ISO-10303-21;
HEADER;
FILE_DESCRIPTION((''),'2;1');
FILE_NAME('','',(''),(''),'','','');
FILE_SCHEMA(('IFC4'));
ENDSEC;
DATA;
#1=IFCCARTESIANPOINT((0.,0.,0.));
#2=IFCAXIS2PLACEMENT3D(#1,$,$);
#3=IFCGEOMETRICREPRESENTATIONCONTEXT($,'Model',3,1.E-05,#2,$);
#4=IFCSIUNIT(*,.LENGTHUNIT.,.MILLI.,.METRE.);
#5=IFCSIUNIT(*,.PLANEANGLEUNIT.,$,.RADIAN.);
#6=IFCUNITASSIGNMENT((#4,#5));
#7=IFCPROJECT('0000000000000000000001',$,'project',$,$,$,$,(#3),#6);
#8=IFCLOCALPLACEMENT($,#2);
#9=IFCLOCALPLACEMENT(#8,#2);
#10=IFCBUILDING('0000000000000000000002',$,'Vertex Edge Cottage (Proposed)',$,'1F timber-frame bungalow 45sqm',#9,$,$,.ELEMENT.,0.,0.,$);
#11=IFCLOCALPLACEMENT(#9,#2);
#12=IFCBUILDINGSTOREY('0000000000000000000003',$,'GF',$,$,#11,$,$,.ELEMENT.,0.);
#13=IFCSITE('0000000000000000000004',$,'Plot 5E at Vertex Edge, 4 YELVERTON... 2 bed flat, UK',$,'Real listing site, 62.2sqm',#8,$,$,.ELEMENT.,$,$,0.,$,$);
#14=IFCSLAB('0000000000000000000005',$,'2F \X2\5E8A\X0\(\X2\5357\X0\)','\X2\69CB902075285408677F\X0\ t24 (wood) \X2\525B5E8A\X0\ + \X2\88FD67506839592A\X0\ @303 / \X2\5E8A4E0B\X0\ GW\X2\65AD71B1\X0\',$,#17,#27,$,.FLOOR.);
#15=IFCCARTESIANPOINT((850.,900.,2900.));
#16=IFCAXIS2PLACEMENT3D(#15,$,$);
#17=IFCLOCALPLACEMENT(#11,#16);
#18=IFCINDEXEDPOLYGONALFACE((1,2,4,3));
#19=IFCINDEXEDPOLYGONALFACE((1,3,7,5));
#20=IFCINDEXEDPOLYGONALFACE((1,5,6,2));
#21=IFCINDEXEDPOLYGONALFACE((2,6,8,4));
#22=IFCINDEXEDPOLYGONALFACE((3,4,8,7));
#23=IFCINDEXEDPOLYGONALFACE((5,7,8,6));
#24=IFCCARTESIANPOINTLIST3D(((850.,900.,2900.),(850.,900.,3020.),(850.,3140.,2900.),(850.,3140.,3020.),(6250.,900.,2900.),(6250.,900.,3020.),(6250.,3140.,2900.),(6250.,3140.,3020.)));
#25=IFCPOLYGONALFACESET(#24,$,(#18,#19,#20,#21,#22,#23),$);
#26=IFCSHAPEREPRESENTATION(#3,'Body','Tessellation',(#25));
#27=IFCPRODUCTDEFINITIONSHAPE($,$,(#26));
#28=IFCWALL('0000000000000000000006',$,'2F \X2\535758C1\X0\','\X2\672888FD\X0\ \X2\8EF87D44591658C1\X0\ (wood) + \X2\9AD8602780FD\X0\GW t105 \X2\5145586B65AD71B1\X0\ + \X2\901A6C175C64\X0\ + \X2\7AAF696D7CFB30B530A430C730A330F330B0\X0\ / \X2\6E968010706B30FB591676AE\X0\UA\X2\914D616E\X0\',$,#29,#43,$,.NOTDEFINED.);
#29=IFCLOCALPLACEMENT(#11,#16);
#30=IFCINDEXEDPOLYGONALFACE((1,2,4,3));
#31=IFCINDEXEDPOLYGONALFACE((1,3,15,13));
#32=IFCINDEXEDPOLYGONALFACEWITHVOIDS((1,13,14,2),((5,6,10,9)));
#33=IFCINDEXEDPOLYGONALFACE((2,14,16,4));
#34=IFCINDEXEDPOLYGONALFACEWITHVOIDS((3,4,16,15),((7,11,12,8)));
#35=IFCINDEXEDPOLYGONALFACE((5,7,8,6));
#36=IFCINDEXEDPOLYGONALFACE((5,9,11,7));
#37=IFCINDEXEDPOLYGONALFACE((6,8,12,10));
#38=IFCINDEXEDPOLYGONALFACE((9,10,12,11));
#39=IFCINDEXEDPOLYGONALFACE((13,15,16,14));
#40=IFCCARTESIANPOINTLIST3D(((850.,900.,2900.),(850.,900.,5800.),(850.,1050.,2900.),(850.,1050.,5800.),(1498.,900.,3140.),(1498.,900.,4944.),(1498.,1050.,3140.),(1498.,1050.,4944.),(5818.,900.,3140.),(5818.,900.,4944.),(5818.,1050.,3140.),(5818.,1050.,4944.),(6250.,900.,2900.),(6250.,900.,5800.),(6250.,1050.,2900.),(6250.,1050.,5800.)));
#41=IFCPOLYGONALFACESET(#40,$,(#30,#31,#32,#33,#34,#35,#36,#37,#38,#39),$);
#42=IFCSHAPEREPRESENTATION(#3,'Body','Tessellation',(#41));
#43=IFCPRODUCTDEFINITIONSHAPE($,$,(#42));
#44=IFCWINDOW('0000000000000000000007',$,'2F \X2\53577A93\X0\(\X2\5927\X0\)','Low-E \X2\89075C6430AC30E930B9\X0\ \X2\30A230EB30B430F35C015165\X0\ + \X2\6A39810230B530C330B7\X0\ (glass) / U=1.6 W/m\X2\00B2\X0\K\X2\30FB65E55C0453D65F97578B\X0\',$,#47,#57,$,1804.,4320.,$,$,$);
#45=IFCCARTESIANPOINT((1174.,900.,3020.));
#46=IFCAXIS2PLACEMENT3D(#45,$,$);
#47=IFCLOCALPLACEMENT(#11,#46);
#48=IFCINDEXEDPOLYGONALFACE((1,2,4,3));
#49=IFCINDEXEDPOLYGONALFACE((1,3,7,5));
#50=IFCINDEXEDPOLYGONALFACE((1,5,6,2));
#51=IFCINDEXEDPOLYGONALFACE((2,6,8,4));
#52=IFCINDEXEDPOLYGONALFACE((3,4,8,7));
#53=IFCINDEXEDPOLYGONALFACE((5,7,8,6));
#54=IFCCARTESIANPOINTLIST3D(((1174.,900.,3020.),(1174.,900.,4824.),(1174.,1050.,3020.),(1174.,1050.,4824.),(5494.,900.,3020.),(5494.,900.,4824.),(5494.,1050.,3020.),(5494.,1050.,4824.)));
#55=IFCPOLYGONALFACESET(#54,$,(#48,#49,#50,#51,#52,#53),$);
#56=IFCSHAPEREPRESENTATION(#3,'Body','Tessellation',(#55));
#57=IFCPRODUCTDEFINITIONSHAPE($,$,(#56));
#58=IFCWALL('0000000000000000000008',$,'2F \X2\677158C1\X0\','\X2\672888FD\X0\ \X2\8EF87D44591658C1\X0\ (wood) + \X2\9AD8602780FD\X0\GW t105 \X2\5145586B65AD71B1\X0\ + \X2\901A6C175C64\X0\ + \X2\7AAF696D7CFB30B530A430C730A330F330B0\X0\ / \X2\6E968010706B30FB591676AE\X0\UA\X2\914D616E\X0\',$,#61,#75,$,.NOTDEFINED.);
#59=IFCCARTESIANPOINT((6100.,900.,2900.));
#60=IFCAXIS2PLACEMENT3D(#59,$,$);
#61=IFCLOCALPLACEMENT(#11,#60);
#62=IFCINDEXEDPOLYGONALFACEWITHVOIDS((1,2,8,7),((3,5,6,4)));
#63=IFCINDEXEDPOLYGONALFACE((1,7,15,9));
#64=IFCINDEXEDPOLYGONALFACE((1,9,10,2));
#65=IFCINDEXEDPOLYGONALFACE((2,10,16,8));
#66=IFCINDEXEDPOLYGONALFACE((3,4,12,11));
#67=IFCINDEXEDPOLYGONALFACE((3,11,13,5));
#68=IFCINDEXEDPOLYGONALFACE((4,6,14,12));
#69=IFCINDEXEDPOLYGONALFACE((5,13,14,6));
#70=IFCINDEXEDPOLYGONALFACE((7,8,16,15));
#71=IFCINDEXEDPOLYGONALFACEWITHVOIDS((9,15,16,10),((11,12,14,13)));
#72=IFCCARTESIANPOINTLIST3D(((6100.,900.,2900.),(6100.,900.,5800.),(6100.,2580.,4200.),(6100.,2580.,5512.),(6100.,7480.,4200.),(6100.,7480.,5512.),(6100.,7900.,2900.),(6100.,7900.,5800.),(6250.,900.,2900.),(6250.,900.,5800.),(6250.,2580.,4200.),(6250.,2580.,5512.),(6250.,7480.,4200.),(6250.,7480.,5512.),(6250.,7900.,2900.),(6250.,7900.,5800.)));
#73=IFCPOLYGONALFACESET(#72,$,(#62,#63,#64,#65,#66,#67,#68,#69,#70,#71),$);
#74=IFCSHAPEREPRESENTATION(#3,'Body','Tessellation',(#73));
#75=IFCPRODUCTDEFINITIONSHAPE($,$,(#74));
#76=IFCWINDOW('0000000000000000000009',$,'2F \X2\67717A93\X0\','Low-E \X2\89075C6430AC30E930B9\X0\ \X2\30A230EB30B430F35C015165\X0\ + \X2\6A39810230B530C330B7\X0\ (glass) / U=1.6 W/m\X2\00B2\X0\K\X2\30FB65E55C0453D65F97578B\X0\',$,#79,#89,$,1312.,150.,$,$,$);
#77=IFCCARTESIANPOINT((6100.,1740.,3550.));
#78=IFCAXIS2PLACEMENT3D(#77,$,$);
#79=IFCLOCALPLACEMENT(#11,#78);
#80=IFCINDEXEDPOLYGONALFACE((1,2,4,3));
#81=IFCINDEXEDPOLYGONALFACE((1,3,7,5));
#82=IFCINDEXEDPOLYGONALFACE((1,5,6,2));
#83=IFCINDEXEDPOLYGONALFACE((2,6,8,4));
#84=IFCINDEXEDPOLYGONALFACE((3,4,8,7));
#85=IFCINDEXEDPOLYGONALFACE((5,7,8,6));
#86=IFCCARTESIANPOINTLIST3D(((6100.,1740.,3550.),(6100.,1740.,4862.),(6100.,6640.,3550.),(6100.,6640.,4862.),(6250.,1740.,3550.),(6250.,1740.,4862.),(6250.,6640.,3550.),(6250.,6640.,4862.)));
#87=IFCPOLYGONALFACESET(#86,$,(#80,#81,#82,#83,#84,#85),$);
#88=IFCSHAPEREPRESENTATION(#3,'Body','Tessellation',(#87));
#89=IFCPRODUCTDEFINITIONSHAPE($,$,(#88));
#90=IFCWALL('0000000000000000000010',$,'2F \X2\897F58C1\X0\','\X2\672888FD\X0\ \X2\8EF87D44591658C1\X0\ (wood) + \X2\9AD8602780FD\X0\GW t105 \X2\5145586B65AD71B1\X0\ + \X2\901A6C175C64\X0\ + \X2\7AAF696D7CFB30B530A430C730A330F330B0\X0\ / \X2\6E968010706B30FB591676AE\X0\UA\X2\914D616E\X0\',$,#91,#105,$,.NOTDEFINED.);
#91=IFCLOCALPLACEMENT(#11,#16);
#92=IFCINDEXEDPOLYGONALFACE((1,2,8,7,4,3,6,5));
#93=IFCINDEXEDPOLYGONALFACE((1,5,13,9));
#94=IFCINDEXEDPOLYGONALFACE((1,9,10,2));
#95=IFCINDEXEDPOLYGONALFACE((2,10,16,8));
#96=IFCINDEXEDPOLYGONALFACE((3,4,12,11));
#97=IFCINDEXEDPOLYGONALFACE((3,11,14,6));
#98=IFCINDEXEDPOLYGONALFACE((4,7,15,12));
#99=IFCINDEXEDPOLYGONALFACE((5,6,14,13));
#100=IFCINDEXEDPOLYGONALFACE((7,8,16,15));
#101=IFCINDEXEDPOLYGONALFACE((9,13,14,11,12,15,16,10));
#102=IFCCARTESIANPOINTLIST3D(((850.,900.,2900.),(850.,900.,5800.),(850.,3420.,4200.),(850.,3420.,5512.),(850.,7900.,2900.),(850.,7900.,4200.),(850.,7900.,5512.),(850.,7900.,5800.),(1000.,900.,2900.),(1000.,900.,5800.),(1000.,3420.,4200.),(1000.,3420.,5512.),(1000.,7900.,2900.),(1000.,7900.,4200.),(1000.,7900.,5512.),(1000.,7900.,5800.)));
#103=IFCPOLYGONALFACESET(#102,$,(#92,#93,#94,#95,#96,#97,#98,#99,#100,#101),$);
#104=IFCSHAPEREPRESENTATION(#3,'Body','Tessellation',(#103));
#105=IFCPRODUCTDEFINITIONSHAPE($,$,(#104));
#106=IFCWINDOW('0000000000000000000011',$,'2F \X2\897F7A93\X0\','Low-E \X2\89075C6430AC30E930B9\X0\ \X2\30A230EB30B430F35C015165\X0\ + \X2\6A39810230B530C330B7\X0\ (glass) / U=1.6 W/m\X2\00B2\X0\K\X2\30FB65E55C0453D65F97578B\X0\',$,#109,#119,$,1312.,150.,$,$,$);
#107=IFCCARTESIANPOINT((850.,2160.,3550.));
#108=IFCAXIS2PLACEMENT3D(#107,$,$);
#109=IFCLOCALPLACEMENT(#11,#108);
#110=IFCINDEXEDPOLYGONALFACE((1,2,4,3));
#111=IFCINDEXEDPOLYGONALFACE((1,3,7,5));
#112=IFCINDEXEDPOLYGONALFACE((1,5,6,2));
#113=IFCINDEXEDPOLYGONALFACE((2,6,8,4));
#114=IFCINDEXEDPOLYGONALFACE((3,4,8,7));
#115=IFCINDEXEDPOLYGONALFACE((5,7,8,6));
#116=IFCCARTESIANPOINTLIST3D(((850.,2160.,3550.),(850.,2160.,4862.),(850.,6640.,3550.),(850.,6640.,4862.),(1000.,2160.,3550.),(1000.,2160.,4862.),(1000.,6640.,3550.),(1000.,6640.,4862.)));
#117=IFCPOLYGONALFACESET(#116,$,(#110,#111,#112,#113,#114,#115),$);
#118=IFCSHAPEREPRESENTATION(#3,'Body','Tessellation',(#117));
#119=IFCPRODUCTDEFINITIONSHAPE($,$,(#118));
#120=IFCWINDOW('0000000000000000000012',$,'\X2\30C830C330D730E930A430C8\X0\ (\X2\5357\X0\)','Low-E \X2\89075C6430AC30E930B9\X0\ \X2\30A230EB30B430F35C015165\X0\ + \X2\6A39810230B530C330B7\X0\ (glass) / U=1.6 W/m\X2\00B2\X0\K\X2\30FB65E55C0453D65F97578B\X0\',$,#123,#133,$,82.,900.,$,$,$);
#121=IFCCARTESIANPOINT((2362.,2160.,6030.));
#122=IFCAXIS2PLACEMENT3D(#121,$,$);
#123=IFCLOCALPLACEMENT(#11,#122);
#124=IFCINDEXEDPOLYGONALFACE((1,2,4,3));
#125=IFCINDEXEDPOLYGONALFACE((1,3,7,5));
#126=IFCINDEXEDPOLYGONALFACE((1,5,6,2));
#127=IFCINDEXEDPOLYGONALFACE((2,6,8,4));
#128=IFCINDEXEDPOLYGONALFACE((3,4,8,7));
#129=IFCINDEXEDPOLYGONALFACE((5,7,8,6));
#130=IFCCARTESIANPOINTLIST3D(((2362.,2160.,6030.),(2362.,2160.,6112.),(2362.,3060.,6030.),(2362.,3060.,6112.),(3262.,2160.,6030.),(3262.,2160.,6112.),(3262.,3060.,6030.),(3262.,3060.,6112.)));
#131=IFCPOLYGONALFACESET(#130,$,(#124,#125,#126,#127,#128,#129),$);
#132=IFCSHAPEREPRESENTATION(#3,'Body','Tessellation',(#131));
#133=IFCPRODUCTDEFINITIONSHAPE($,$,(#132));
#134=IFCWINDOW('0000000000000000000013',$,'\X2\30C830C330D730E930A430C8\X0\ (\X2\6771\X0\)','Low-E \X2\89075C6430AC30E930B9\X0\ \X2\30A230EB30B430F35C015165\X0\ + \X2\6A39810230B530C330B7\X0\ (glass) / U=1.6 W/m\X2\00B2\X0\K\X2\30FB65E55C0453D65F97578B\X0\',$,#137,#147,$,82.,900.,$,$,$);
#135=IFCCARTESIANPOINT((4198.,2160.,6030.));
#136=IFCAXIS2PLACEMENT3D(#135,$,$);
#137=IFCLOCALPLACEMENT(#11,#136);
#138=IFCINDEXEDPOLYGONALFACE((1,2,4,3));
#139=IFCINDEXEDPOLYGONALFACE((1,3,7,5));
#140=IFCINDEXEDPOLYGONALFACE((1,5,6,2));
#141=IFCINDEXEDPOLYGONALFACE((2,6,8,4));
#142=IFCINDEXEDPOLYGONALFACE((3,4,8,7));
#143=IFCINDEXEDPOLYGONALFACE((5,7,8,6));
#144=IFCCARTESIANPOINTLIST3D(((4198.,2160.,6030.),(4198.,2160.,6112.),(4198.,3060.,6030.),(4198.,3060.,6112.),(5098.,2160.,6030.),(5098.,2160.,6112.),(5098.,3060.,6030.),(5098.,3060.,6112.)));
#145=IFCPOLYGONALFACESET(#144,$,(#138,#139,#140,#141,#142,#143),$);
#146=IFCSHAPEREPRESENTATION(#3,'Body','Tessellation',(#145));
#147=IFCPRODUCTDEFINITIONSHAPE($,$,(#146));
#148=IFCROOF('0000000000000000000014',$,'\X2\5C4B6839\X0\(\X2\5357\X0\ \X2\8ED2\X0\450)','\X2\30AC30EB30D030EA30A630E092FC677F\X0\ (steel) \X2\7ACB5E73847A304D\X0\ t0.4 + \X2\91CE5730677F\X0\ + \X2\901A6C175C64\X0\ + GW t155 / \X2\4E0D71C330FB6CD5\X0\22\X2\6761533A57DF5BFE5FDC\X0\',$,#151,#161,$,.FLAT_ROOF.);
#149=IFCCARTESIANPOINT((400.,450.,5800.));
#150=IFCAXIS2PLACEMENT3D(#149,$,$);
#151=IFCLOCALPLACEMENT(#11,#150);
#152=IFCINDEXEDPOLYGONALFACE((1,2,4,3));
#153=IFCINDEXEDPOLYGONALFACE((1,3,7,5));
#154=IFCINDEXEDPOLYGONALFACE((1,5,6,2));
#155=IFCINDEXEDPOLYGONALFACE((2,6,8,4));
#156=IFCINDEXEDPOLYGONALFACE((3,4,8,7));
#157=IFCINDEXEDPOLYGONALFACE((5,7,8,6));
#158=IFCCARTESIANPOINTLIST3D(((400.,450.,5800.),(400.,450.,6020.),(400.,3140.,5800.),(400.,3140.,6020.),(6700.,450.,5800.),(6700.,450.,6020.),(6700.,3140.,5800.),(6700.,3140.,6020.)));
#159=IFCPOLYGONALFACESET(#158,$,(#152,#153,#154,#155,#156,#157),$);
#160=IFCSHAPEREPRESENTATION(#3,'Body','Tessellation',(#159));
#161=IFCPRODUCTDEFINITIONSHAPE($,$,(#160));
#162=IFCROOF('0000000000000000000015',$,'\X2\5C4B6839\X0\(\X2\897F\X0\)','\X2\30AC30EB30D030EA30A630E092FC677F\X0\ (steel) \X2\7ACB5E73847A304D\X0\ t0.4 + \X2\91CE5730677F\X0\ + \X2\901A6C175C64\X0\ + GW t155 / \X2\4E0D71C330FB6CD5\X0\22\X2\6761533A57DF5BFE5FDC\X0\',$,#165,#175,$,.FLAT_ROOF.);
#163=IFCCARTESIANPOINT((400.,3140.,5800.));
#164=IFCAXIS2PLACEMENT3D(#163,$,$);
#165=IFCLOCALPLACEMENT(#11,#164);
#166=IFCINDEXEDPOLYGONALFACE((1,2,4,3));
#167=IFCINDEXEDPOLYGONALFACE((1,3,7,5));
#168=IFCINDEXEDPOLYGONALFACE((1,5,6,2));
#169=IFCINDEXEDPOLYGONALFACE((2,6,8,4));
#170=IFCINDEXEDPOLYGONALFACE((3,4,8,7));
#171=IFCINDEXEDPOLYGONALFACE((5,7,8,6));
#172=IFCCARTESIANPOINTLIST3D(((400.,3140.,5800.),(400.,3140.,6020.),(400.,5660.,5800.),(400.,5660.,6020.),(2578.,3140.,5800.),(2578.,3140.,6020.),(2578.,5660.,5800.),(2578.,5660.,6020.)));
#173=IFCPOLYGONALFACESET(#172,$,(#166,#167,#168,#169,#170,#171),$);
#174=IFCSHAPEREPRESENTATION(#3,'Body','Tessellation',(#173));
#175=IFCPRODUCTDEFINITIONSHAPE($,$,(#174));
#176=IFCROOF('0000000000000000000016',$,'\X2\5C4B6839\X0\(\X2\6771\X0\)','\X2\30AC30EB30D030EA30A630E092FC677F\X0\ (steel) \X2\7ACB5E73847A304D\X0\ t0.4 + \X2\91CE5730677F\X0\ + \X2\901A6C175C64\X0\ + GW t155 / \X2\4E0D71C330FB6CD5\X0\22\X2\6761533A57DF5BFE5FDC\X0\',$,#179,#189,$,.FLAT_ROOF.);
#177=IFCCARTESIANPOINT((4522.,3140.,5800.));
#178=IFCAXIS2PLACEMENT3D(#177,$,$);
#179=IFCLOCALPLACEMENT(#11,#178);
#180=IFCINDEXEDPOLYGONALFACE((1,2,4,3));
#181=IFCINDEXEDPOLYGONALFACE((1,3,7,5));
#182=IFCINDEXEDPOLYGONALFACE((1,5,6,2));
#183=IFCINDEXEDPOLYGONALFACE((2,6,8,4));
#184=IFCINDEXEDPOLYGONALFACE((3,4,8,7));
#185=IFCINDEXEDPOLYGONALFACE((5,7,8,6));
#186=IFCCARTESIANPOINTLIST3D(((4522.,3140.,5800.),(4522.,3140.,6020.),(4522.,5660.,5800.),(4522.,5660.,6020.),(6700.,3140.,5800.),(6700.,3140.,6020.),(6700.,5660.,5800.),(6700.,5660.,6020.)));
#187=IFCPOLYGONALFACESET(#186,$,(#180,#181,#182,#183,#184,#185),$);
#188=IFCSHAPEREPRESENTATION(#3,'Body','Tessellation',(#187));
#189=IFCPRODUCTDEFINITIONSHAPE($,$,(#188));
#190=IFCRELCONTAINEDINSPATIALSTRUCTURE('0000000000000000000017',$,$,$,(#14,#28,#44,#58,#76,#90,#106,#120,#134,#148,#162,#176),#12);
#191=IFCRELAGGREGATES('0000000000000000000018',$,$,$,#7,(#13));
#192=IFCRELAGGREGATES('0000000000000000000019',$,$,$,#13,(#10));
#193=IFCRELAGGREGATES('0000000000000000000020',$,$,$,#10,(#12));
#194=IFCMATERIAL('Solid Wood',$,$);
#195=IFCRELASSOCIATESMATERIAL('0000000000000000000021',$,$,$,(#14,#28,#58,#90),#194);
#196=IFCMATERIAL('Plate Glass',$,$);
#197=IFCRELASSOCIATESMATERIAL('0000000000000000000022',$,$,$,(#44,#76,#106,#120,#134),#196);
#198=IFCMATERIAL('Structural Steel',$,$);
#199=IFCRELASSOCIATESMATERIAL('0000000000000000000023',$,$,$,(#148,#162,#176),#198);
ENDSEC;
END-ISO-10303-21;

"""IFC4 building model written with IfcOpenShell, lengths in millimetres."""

from ifc_helpers import new_model, si_unit, frame, frame_2d, origin, place, context, project, spatial, rectangle, extrude, material, element, fill, save


model = new_model("IFC4")

# Units and contexts
model_context = context("Model", 3, precision=1e-05, world=origin())
ifc_project = project(units=[si_unit("LENGTHUNIT", "METRE", prefix="MILLI"), si_unit("PLANEANGLEUNIT", "RADIAN")], contexts=[model_context])

# Site, building, storey
site_placement = place(None, origin())
site = spatial("IfcSite", under=ifc_project, at=site_placement, Name="Plot 5E at Vertex Edge, 4 YELVERTON... 2 bed flat, UK", ObjectType="Real listing site, 62.2sqm", CompositionType="ELEMENT", RefElevation=0.0)
building_placement = place(site_placement, origin())
building = spatial("IfcBuilding", under=site, at=building_placement, Name="Vertex Edge Cottage (Proposed)", ObjectType="1F timber-frame bungalow 45sqm", CompositionType="ELEMENT", ElevationOfRefHeight=0.0, ElevationOfTerrain=0.0)
storey_placement = place(building_placement, origin())
storey = spatial("IfcBuildingStorey", under=building, at=storey_placement, Name="GF", CompositionType="ELEMENT", Elevation=0.0)

# Slab
ifc_material_1 = material(Name="Solid Wood")
slab_placement = place(storey_placement, frame((850.0, 900.0, 2900.0)))
element("IfcSlab", 1, at=slab_placement, inside=storey, material=ifc_material_1, Name="2F 床(南)", Description="構造用合板 t24 (wood) 剛床 + 製材根太 @303 / 床下 GW断熱", PredefinedType="FLOOR", context=model_context, shape_type="SweptSolid", body=[
    extrude(rectangle(XDim=5400.0, YDim=2240.0, at=frame_2d((2700.0, 1120.0))), frame((850.0, 900.0, 2900.0)), (0.0, 0.0, 1.0), 120.0),
])

# Walls, openings, windows
wall_1_placement = place(storey_placement, frame((850.0, 900.0, 2900.0)))
wall_1 = element("IfcWall", 2, at=wall_1_placement, inside=storey, material=ifc_material_1, Name="2F 南壁", Description="木製 軸組外壁 (wood) + 高性能GW t105 充填断熱 + 通気層 + 窯業系サイディング / 準耐火・外皮UA配慮", PredefinedType="NOTDEFINED", context=model_context, shape_type="SweptSolid", body=[
    extrude(rectangle(XDim=5400.0, YDim=150.0, at=frame_2d((2700.0, 75.0))), frame((850.0, 900.0, 2900.0)), (0.0, 0.0, 1.0), 2900.0),
])
opening_1_placement = place(storey_placement, frame((1174.0, 900.0, 3020.0)))
opening_1 = element("IfcOpeningElement", 3, at=opening_1_placement, cuts=wall_1, PredefinedType="NOTDEFINED", context=model_context, shape_type="SweptSolid", body=[
    extrude(rectangle(XDim=4320.0, YDim=150.0, at=frame_2d((2160.0, 75.0))), frame((1174.0, 900.0, 3020.0)), (0.0, 0.0, 1.0), 1804.0),
])
ifc_material_2 = material(Name="Plate Glass")
window_1_placement = place(storey_placement, frame((1174.0, 900.0, 3020.0)))
window_1 = element("IfcWindow", 4, at=window_1_placement, inside=storey, material=ifc_material_2, Name="2F 南窓(大)", Description="Low-E 複層ガラス アルゴン封入 + 樹脂サッシ (glass) / U=1.6 W/m²K・日射取得型", OverallHeight=1804.0, OverallWidth=4320.0, context=model_context, shape_type="SweptSolid", body=[
    extrude(rectangle(XDim=4320.0, YDim=150.0, at=frame_2d((2160.0, 75.0))), frame((1174.0, 900.0, 3020.0)), (0.0, 0.0, 1.0), 1804.0),
])
fill(opening_1, window_1)
wall_2_placement = place(storey_placement, frame((6100.0, 900.0, 2900.0)))
wall_2 = element("IfcWall", 5, at=wall_2_placement, inside=storey, material=ifc_material_1, Name="2F 東壁", Description="木製 軸組外壁 (wood) + 高性能GW t105 充填断熱 + 通気層 + 窯業系サイディング / 準耐火・外皮UA配慮", PredefinedType="NOTDEFINED", context=model_context, shape_type="SweptSolid", body=[
    extrude(rectangle(XDim=150.0, YDim=7000.0, at=frame_2d((75.0, 3500.0))), frame((6100.0, 900.0, 2900.0)), (0.0, 0.0, 1.0), 2900.0),
])
opening_2_placement = place(storey_placement, frame((6100.0, 1740.0, 3550.0)))
opening_2 = element("IfcOpeningElement", 6, at=opening_2_placement, cuts=wall_2, PredefinedType="NOTDEFINED", context=model_context, shape_type="SweptSolid", body=[
    extrude(rectangle(XDim=150.0, YDim=4900.0, at=frame_2d((75.0, 2450.0))), frame((6100.0, 1740.0, 3550.0)), (0.0, 0.0, 1.0), 1312.0),
])
window_2_placement = place(storey_placement, frame((6100.0, 1740.0, 3550.0)))
window_2 = element("IfcWindow", 7, at=window_2_placement, inside=storey, material=ifc_material_2, Name="2F 東窓", Description="Low-E 複層ガラス アルゴン封入 + 樹脂サッシ (glass) / U=1.6 W/m²K・日射取得型", OverallHeight=1312.0, OverallWidth=150.0, context=model_context, shape_type="SweptSolid", body=[
    extrude(rectangle(XDim=150.0, YDim=4900.0, at=frame_2d((75.0, 2450.0))), frame((6100.0, 1740.0, 3550.0)), (0.0, 0.0, 1.0), 1312.0),
])
fill(opening_2, window_2)
wall_3_placement = place(storey_placement, frame((850.0, 900.0, 2900.0)))
wall_3 = element("IfcWall", 8, at=wall_3_placement, inside=storey, material=ifc_material_1, Name="2F 西壁", Description="木製 軸組外壁 (wood) + 高性能GW t105 充填断熱 + 通気層 + 窯業系サイディング / 準耐火・外皮UA配慮", PredefinedType="NOTDEFINED", context=model_context, shape_type="SweptSolid", body=[
    extrude(rectangle(XDim=150.0, YDim=7000.0, at=frame_2d((75.0, 3500.0))), frame((850.0, 900.0, 2900.0)), (0.0, 0.0, 1.0), 2900.0),
])
opening_3_placement = place(storey_placement, frame((850.0, 2160.0, 3550.0)))
opening_3 = element("IfcOpeningElement", 9, at=opening_3_placement, cuts=wall_3, PredefinedType="NOTDEFINED", context=model_context, shape_type="SweptSolid", body=[
    extrude(rectangle(XDim=150.0, YDim=4480.0, at=frame_2d((75.0, 2240.0))), frame((850.0, 2160.0, 3550.0)), (0.0, 0.0, 1.0), 1312.0),
])
window_3_placement = place(storey_placement, frame((850.0, 2160.0, 3550.0)))
window_3 = element("IfcWindow", 10, at=window_3_placement, inside=storey, material=ifc_material_2, Name="2F 西窓", Description="Low-E 複層ガラス アルゴン封入 + 樹脂サッシ (glass) / U=1.6 W/m²K・日射取得型", OverallHeight=1312.0, OverallWidth=150.0, context=model_context, shape_type="SweptSolid", body=[
    extrude(rectangle(XDim=150.0, YDim=4480.0, at=frame_2d((75.0, 2240.0))), frame((850.0, 2160.0, 3550.0)), (0.0, 0.0, 1.0), 1312.0),
])
fill(opening_3, window_3)

# Windows
window_4_placement = place(storey_placement, frame((2362.0, 2160.0, 6030.0)))
element("IfcWindow", 11, at=window_4_placement, inside=storey, material=ifc_material_2, Name="トップライト (南)", Description="Low-E 複層ガラス アルゴン封入 + 樹脂サッシ (glass) / U=1.6 W/m²K・日射取得型", OverallHeight=82.0, OverallWidth=900.0, context=model_context, shape_type="SweptSolid", body=[
    extrude(rectangle(XDim=900.0, YDim=900.0, at=frame_2d((450.0, 450.0))), frame((2362.0, 2160.0, 6030.0)), (0.0, 0.0, 1.0), 82.0),
])
window_5_placement = place(storey_placement, frame((4198.0, 2160.0, 6030.0)))
element("IfcWindow", 12, at=window_5_placement, inside=storey, material=ifc_material_2, Name="トップライト (東)", Description="Low-E 複層ガラス アルゴン封入 + 樹脂サッシ (glass) / U=1.6 W/m²K・日射取得型", OverallHeight=82.0, OverallWidth=900.0, context=model_context, shape_type="SweptSolid", body=[
    extrude(rectangle(XDim=900.0, YDim=900.0, at=frame_2d((450.0, 450.0))), frame((4198.0, 2160.0, 6030.0)), (0.0, 0.0, 1.0), 82.0),
])

# Roofs
ifc_material_3 = material(Name="Structural Steel")
roof_1_placement = place(storey_placement, frame((400.0, 450.0, 5800.0)))
element("IfcRoof", 13, at=roof_1_placement, inside=storey, material=ifc_material_3, Name="屋根(南 軒450)", Description="ガルバリウム鋼板 (steel) 立平葺き t0.4 + 野地板 + 通気層 + GW t155 / 不燃・法22条区域対応", PredefinedType="FLAT_ROOF", context=model_context, shape_type="SweptSolid", body=[
    extrude(rectangle(XDim=6300.0, YDim=2690.0, at=frame_2d((3150.0, 1345.0))), frame((400.0, 450.0, 5800.0)), (0.0, 0.0, 1.0), 220.0),
])
roof_2_placement = place(storey_placement, frame((400.0, 3140.0, 5800.0)))
element("IfcRoof", 14, at=roof_2_placement, inside=storey, material=ifc_material_3, Name="屋根(西)", Description="ガルバリウム鋼板 (steel) 立平葺き t0.4 + 野地板 + 通気層 + GW t155 / 不燃・法22条区域対応", PredefinedType="FLAT_ROOF", context=model_context, shape_type="SweptSolid", body=[
    extrude(rectangle(XDim=2178.0, YDim=2520.0, at=frame_2d((1089.0, 1260.0))), frame((400.0, 3140.0, 5800.0)), (0.0, 0.0, 1.0), 220.0),
])
roof_3_placement = place(storey_placement, frame((4522.0, 3140.0, 5800.0)))
element("IfcRoof", 15, at=roof_3_placement, inside=storey, material=ifc_material_3, Name="屋根(東)", Description="ガルバリウム鋼板 (steel) 立平葺き t0.4 + 野地板 + 通気層 + GW t155 / 不燃・法22条区域対応", PredefinedType="FLAT_ROOF", context=model_context, shape_type="SweptSolid", body=[
    extrude(rectangle(XDim=2178.0, YDim=2520.0, at=frame_2d((1089.0, 1260.0))), frame((4522.0, 3140.0, 5800.0)), (0.0, 0.0, 1.0), 220.0),
])

save(model, "model.ifc")
